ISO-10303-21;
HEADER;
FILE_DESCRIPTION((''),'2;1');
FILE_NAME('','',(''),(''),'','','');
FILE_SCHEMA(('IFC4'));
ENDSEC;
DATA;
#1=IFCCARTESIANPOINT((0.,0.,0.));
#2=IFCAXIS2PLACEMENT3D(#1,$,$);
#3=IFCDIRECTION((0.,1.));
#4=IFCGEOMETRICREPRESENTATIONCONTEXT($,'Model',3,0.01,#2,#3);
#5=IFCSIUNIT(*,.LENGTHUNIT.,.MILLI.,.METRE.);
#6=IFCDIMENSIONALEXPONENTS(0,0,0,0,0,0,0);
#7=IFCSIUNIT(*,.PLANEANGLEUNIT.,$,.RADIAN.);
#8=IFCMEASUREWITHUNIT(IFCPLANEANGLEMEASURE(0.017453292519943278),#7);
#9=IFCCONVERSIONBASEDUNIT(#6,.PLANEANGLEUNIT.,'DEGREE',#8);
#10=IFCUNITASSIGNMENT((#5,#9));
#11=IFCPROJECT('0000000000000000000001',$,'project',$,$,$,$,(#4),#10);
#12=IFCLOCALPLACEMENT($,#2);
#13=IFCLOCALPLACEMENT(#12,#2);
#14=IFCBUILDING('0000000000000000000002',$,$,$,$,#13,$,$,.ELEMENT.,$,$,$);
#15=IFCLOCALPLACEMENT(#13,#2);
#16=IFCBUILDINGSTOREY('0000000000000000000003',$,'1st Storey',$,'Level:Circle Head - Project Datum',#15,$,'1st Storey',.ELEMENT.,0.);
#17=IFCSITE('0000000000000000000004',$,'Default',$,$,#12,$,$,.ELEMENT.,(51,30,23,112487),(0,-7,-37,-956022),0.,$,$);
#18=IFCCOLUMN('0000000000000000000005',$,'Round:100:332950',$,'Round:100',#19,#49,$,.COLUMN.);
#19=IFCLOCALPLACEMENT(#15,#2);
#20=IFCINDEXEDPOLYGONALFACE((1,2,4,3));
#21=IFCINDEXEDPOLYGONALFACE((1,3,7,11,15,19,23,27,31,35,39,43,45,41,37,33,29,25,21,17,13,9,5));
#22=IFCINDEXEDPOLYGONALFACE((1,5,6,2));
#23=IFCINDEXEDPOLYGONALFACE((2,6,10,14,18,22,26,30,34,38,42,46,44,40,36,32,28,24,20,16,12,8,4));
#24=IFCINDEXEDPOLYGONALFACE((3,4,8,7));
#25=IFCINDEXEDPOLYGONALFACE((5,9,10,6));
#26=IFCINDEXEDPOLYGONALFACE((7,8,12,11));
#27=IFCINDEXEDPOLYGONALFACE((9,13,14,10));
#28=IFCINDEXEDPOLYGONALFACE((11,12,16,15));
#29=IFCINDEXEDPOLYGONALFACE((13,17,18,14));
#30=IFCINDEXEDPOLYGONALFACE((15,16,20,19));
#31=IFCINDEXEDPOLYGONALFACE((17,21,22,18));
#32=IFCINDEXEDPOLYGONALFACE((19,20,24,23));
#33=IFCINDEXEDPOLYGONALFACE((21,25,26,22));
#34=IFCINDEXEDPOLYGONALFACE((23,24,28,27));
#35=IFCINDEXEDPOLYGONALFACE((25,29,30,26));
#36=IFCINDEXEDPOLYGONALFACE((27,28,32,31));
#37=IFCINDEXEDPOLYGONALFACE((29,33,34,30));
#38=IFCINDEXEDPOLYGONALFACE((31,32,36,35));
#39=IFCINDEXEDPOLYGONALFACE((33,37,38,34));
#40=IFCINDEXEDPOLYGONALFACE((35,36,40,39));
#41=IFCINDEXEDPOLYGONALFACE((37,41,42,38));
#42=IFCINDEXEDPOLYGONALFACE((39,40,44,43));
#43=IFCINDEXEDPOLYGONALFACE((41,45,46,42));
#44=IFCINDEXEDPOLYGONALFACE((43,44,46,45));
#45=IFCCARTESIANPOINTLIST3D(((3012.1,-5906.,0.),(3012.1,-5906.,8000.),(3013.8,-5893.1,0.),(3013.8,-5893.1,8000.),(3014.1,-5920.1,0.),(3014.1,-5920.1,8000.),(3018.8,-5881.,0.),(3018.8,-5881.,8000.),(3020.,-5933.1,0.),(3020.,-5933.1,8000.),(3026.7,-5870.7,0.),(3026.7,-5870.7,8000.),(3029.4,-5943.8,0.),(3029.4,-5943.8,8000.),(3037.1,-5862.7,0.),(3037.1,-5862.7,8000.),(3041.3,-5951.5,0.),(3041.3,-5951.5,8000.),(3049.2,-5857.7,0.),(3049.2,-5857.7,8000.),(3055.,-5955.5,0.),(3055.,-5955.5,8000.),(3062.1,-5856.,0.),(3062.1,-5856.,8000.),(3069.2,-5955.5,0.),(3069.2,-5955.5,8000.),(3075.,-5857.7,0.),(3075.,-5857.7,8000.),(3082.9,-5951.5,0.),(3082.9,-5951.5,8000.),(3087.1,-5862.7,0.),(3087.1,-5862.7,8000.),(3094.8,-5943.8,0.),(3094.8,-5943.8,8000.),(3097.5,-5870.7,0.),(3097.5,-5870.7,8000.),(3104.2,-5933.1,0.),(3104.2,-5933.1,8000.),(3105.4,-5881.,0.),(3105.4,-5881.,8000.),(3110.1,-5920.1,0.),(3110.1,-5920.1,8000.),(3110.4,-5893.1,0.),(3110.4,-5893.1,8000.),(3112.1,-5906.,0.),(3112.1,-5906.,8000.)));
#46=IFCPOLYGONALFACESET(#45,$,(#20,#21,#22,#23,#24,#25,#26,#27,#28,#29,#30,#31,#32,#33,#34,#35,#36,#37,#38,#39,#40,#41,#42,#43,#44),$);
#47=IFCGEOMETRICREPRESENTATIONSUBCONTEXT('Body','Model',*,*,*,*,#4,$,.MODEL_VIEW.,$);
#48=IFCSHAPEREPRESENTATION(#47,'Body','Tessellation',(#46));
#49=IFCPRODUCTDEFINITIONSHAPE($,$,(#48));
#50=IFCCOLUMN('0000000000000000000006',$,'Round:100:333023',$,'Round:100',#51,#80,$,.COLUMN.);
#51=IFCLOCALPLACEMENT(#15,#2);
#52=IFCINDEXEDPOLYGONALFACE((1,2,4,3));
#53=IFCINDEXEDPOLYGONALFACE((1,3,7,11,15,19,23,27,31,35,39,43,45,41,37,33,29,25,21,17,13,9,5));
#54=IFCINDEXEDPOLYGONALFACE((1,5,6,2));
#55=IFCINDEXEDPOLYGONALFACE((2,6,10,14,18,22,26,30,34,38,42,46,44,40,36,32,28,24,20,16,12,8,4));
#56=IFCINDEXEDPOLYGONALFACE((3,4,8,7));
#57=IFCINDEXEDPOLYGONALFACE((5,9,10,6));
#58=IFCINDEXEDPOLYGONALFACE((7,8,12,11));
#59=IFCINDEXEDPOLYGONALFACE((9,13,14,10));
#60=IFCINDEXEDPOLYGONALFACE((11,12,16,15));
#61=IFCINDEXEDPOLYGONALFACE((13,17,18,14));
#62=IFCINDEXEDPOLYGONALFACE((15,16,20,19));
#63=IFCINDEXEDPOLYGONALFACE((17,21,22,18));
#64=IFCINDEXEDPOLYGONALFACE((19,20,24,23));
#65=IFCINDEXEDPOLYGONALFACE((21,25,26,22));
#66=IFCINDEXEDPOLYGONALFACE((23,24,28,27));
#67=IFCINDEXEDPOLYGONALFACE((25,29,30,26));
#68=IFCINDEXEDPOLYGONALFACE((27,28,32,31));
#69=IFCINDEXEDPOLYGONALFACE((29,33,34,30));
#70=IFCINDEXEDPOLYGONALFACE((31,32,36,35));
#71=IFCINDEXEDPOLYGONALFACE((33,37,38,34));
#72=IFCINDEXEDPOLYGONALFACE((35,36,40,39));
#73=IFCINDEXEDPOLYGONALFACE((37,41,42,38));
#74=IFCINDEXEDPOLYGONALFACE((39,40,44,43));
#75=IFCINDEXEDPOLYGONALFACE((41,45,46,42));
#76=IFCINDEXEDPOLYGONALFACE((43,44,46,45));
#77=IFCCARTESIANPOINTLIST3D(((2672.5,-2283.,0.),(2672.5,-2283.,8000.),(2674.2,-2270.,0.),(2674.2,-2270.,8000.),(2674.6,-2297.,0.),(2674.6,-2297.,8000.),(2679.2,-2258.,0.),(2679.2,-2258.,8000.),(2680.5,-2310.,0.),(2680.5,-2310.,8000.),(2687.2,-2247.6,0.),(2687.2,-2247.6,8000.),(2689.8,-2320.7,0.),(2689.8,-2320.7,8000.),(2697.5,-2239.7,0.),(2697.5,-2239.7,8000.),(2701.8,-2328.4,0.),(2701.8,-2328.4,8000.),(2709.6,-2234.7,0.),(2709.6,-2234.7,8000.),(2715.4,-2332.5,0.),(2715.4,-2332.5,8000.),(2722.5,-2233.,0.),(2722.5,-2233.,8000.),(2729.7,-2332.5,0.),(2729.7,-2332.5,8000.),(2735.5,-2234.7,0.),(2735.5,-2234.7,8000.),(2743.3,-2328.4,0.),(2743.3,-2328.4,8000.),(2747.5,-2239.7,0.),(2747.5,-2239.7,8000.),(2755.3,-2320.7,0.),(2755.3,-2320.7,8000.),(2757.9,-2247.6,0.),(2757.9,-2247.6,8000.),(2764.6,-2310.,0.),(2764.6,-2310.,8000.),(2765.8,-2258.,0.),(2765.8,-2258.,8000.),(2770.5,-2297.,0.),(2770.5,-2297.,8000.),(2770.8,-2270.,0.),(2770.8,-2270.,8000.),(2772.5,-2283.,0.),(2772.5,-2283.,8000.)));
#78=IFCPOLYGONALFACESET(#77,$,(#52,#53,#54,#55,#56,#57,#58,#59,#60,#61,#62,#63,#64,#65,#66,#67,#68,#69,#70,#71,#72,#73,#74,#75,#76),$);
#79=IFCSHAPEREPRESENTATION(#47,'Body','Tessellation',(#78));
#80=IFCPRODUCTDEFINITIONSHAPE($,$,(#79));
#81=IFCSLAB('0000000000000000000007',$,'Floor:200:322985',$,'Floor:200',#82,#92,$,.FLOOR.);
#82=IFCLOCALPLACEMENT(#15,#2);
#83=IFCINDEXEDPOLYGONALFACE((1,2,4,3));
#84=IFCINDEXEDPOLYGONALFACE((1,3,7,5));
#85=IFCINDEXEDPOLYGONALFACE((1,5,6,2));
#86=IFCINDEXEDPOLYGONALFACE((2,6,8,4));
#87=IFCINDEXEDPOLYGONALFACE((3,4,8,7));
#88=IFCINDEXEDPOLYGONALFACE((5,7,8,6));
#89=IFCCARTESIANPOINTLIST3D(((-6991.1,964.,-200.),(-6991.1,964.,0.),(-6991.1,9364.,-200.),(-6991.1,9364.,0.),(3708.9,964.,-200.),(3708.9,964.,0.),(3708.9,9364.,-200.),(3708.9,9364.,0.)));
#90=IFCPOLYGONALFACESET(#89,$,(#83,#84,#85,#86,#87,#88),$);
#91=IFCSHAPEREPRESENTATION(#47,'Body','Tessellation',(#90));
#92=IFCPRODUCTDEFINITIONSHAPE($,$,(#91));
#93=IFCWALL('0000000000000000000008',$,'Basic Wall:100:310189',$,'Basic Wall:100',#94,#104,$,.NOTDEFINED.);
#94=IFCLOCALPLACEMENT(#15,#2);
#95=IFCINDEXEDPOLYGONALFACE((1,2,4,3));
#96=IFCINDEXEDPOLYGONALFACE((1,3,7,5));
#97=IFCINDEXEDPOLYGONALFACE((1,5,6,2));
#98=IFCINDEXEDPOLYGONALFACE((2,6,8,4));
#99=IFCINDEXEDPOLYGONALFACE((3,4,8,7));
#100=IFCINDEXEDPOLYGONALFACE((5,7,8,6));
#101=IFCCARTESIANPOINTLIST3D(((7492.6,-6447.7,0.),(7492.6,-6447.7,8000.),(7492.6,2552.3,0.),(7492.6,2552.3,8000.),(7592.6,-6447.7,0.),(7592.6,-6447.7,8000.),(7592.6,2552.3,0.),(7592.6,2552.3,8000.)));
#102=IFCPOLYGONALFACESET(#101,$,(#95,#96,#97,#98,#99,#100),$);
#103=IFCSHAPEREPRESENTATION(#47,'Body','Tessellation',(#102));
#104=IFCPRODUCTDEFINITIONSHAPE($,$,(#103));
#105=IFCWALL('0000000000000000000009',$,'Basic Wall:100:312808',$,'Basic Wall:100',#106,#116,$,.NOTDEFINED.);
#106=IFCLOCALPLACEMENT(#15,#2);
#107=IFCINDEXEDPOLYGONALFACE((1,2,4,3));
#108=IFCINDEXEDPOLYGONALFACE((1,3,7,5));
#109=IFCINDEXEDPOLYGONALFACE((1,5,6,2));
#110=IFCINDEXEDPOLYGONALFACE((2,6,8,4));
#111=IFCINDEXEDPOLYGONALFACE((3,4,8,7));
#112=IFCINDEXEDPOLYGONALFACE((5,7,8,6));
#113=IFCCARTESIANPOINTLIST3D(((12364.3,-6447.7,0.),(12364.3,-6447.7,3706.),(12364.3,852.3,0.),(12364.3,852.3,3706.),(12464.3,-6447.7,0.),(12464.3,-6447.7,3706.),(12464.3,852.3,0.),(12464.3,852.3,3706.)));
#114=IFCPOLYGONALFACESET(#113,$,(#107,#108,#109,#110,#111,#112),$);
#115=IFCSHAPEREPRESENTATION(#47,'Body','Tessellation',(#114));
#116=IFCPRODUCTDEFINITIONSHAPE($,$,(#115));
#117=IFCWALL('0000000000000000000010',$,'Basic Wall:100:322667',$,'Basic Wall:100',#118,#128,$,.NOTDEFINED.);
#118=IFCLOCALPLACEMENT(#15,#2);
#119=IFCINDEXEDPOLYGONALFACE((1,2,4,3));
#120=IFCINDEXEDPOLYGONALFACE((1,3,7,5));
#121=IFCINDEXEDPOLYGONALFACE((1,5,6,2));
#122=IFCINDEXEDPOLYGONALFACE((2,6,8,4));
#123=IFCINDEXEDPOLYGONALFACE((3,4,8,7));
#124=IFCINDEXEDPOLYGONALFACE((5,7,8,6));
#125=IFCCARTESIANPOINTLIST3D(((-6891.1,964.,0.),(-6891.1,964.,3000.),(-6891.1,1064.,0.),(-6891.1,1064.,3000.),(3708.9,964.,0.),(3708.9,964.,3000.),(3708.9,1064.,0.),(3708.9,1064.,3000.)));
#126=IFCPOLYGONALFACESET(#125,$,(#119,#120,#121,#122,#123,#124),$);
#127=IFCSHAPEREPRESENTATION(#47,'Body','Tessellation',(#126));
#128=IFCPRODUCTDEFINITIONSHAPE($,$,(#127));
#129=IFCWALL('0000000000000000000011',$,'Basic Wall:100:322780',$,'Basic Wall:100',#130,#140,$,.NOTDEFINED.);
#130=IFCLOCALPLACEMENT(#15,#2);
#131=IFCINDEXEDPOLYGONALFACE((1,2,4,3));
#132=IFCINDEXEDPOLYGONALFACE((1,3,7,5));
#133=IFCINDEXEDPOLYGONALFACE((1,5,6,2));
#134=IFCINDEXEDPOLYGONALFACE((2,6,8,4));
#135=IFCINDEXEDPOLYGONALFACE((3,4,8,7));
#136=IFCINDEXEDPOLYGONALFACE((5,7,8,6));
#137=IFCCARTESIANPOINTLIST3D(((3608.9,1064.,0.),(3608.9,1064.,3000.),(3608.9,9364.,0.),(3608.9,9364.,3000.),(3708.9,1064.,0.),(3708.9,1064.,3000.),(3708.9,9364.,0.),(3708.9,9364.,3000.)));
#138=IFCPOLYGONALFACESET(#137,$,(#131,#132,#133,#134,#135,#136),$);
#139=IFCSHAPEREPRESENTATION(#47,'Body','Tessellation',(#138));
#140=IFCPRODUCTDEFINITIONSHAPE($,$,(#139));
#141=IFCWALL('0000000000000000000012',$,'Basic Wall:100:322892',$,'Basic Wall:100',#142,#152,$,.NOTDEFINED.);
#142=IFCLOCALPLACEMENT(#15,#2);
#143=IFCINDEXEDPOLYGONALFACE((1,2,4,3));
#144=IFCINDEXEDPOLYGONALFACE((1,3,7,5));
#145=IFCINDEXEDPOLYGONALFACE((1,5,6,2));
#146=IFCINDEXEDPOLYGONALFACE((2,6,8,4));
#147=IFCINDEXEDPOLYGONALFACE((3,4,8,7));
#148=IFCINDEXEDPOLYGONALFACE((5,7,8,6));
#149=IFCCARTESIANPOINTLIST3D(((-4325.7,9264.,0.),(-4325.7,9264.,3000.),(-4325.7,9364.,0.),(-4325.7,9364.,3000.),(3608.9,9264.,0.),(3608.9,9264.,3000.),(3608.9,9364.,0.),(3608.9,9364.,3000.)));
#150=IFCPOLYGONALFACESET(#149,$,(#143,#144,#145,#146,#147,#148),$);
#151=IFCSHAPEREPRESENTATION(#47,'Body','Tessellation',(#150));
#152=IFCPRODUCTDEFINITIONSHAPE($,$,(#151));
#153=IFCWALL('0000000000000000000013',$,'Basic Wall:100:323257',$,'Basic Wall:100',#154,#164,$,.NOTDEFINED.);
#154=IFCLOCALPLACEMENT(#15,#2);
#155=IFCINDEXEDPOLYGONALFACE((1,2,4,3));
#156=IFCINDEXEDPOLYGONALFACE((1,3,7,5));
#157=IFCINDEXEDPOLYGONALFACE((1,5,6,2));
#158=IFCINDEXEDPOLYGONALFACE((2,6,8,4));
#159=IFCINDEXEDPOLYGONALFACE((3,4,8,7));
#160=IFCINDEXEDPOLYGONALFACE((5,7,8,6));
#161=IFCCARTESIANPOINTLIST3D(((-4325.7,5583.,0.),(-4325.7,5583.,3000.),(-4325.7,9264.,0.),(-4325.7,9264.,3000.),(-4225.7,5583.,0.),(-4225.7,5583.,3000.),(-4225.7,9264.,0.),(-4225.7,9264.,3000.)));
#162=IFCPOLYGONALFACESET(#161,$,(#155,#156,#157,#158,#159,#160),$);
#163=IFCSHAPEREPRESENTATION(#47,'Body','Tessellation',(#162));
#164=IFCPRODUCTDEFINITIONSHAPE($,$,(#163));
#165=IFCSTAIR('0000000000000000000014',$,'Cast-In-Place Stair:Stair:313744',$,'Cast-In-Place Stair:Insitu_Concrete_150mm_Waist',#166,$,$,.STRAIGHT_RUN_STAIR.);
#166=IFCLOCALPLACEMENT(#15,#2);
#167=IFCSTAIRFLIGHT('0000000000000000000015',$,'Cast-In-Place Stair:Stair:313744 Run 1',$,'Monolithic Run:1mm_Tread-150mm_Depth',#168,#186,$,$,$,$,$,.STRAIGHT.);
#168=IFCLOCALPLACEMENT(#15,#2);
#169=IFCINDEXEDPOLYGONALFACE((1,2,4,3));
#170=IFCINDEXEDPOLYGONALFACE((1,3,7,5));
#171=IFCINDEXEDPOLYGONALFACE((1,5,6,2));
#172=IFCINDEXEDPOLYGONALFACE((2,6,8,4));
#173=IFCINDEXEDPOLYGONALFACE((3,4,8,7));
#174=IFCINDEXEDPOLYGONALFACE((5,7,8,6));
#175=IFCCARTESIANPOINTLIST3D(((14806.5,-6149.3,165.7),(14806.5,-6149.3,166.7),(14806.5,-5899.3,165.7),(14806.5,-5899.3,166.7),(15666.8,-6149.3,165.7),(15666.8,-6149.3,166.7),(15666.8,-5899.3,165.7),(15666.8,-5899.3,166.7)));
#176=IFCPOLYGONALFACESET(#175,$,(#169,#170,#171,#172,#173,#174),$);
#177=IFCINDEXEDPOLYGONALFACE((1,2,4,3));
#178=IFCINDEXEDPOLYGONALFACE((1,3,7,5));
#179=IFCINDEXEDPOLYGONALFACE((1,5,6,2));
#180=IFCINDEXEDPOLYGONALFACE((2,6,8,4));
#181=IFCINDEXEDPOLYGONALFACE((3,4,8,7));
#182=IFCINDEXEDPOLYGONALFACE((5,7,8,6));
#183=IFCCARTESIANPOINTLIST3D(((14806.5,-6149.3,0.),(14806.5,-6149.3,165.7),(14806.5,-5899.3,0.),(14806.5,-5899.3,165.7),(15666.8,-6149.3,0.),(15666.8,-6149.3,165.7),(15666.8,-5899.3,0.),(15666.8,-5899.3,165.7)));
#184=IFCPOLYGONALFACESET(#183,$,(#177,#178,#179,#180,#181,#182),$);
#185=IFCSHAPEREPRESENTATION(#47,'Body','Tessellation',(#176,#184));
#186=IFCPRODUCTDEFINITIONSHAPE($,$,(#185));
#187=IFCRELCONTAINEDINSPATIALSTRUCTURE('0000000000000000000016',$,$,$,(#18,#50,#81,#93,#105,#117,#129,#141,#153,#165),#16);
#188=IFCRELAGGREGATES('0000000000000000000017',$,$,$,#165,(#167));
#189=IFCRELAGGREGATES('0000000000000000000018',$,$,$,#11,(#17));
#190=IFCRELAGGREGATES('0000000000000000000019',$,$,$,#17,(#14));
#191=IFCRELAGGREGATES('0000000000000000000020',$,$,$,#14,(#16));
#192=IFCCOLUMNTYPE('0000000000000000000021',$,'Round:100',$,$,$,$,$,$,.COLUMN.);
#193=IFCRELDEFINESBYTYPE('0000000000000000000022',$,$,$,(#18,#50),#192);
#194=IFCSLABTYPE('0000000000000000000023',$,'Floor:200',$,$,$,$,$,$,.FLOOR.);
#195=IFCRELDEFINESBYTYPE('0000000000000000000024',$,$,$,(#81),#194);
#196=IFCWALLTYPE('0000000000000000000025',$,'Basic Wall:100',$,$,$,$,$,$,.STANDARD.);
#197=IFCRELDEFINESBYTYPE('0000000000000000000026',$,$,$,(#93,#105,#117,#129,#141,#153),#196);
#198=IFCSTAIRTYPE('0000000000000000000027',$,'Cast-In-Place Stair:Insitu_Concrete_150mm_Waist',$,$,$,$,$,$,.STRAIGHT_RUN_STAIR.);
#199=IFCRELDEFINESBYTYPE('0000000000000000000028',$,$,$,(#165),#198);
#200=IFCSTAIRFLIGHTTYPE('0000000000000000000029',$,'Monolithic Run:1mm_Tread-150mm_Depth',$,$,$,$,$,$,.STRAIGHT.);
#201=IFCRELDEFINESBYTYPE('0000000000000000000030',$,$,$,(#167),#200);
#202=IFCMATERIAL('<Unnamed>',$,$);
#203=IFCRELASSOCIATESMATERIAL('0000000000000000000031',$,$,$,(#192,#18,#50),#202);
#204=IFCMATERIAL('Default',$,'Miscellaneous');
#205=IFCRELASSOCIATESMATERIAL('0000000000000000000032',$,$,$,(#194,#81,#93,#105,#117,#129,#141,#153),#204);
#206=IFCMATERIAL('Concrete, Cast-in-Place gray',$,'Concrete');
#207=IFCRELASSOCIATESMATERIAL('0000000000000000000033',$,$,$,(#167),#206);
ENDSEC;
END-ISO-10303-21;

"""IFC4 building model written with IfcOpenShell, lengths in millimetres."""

from ifc_helpers import new_model, entity, si_unit, converted_unit, direction, frame, origin, place, context, subcontext, project, spatial, arc, indexed_curve, outline, extrude, source, transform, mapped, material, type_object, type_shapes, element, aggregate, save


model = new_model("IFC4")

# Units and contexts
model_context = context("Model", 3, precision=0.01, world=origin(), true_north=direction((0.0, 1.0)))
body_context = subcontext(model_context, "Body", "Model", "MODEL_VIEW")
ifc_project = project(units=[si_unit("LENGTHUNIT", "METRE", prefix="MILLI"), converted_unit("PLANEANGLEUNIT", "DEGREE", entity("IfcPlaneAngleMeasure", 0.017453292519943278), si_unit("PLANEANGLEUNIT", "RADIAN"), dimensions=[0, 0, 0, 0, 0, 0, 0])], contexts=[model_context])

# Site, building, storey
site_placement = place(None, origin())
site = spatial("IfcSite", under=ifc_project, at=site_placement, Name="Default", CompositionType="ELEMENT", RefLatitude=(51, 30, 23, 112487), RefLongitude=(0, -7, -37, -956022), RefElevation=0.0)
building_placement = place(site_placement, origin())
building = spatial("IfcBuilding", under=site, at=building_placement, CompositionType="ELEMENT")
storey_placement = place(building_placement, origin())
storey = spatial("IfcBuildingStorey", under=building, at=storey_placement, Name="1st Storey", ObjectType="Level:Circle Head - Project Datum", LongName="1st Storey", CompositionType="ELEMENT", Elevation=0.0)

# Columns
ifc_material_1 = material(Name="<Unnamed>")
column_type = type_object("IfcColumnType", Name="Round:100", PredefinedType="COLUMN", material=ifc_material_1)
shared_shape = source(origin(), body_context, "Body", "SweptSolid", [
    extrude(outline(indexed_curve([(50.0, -16.7), (35.4, 18.7), (0.0, 33.3), (-35.4, 18.7), (-50.0, -16.7), (0.0, -66.7)], segments=[arc(1, 2, 3), arc(3, 4, 5), arc(5, 6, 1)], self_intersect=False)), frame((0.0, 16.7, 0.0)), (0.0, 0.0, 1.0), 8000.0),
])
type_shapes(column_type, [shared_shape])
for number, where, name in (
    (1, (3062.1, -5906.0, 0.0), "Round:100:332950"),
    (2, (2722.5, -2283.0, 0.0), "Round:100:333023"),
):
    element("IfcColumn", number, at=place(storey_placement, frame(where)), inside=storey, type_object=column_type, material=ifc_material_1, Name=name, ObjectType="Round:100", PredefinedType="COLUMN", context=body_context, shape_type="MappedRepresentation", body=[
        mapped(shared_shape, transform((0.0, 0.0, 0.0), scale=1.0)),
    ])

# Slab
ifc_material_2 = material(Name="Default", Category="Miscellaneous")
slab_type = type_object("IfcSlabType", Name="Floor:200", PredefinedType="FLOOR", material=ifc_material_2)
slab_placement = place(storey_placement, origin())
element("IfcSlab", 3, at=slab_placement, inside=storey, type_object=slab_type, material=ifc_material_2, Name="Floor:200:322985", ObjectType="Floor:200", PredefinedType="FLOOR", context=body_context, shape_type="SweptSolid", body=[
    extrude(outline(indexed_curve([(-4200.0, -5350.0), (4200.0, -5350.0), (4200.0, 5350.0), (-4200.0, 5350.0), (-4200.0, -5350.0)], self_intersect=False)), frame((-1641.1, 5164.0, 0.0), z_axis=(0.0, 0.0, -1.0), x_axis=(0.0, 1.0, 0.0)), (0.0, 0.0, 1.0), 200.0),
])

# Walls
wall_type = type_object("IfcWallType", Name="Basic Wall:100", PredefinedType="STANDARD")
wall_1_placement = place(storey_placement, frame((7542.6, 2552.3, 0.0), z_axis=(0.0, 0.0, 1.0), x_axis=(0.0, -1.0, 0.0)))
element("IfcWall", 4, at=wall_1_placement, inside=storey, type_object=wall_type, material=ifc_material_2, Name="Basic Wall:100:310189", ObjectType="Basic Wall:100", PredefinedType="NOTDEFINED", context=body_context, shape_type="SweptSolid", body=[
    extrude(outline(indexed_curve([(9000.0, 50.0), (0.0, 50.0), (0.0, -50.0), (9000.0, -50.0), (9000.0, 50.0)], self_intersect=False)), origin(), (0.0, 0.0, 1.0), 8000.0),
])
wall_2_placement = place(storey_placement, frame((12414.3, -6447.7, 0.0), z_axis=(0.0, 0.0, 1.0), x_axis=(0.0, 1.0, 0.0)))
element("IfcWall", 5, at=wall_2_placement, inside=storey, type_object=wall_type, material=ifc_material_2, Name="Basic Wall:100:312808", ObjectType="Basic Wall:100", PredefinedType="NOTDEFINED", context=body_context, shape_type="SweptSolid", body=[
    extrude(outline(indexed_curve([(7300.0, 50.0), (0.0, 50.0), (0.0, -50.0), (7300.0, -50.0), (7300.0, 50.0)], self_intersect=False)), origin(), (0.0, 0.0, 1.0), 3706.0),
])
wall_3_placement = place(storey_placement, frame((-6891.1, 1014.0, 0.0)))
element("IfcWall", 6, at=wall_3_placement, inside=storey, type_object=wall_type, material=ifc_material_2, Name="Basic Wall:100:322667", ObjectType="Basic Wall:100", PredefinedType="NOTDEFINED", context=body_context, shape_type="SweptSolid", body=[
    extrude(outline(indexed_curve([(10600.0, 50.0), (0.0, 50.0), (0.0, -50.0), (10600.0, -50.0), (10600.0, 50.0)], self_intersect=False)), origin(), (0.0, 0.0, 1.0), 3000.0),
])
wall_4_placement = place(storey_placement, frame((3658.9, 1064.0, 0.0), z_axis=(0.0, 0.0, 1.0), x_axis=(0.0, 1.0, 0.0)))
element("IfcWall", 7, at=wall_4_placement, inside=storey, type_object=wall_type, material=ifc_material_2, Name="Basic Wall:100:322780", ObjectType="Basic Wall:100", PredefinedType="NOTDEFINED", context=body_context, shape_type="SweptSolid", body=[
    extrude(outline(indexed_curve([(8300.0, 50.0), (0.0, 50.0), (0.0, -50.0), (8300.0, -50.0), (8300.0, 50.0)], self_intersect=False)), origin(), (0.0, 0.0, 1.0), 3000.0),
])
wall_5_placement = place(storey_placement, frame((3608.9, 9314.0, 0.0), z_axis=(0.0, 0.0, 1.0), x_axis=(-1.0, 0.0, 0.0)))
element("IfcWall", 8, at=wall_5_placement, inside=storey, type_object=wall_type, material=ifc_material_2, Name="Basic Wall:100:322892", ObjectType="Basic Wall:100", PredefinedType="NOTDEFINED", context=body_context, shape_type="SweptSolid", body=[
    extrude(outline(indexed_curve([(7934.6, 50.0), (0.0, 50.0), (0.0, -50.0), (7934.6, -50.0), (7934.6, 50.0)], self_intersect=False)), origin(), (0.0, 0.0, 1.0), 3000.0),
])
wall_6_placement = place(storey_placement, frame((-4275.7, 5583.0, 0.0), z_axis=(0.0, 0.0, 1.0), x_axis=(0.0, 1.0, 0.0)))
element("IfcWall", 9, at=wall_6_placement, inside=storey, type_object=wall_type, material=ifc_material_2, Name="Basic Wall:100:323257", ObjectType="Basic Wall:100", PredefinedType="NOTDEFINED", context=body_context, shape_type="SweptSolid", body=[
    extrude(outline(indexed_curve([(3681.0, 50.0), (0.0, 50.0), (0.0, -50.0), (3681.0, -50.0), (3681.0, 50.0)], self_intersect=False)), origin(), (0.0, 0.0, 1.0), 3000.0),
])

# Stair, stair flight
stair_type_1 = type_object("IfcStairType", Name="Cast-In-Place Stair:Insitu_Concrete_150mm_Waist", PredefinedType="STRAIGHT_RUN_STAIR")
stair_1_placement = place(storey_placement, origin())
stair_1 = element("IfcStair", 10, at=stair_1_placement, inside=storey, type_object=stair_type_1, Name="Cast-In-Place Stair:Stair:313744", ObjectType="Cast-In-Place Stair:Insitu_Concrete_150mm_Waist", PredefinedType="STRAIGHT_RUN_STAIR")
ifc_material_3 = material(Name="Concrete, Cast-in-Place gray", Category="Concrete")
stair_flight_type = type_object("IfcStairFlightType", Name="Monolithic Run:1mm_Tread-150mm_Depth", PredefinedType="STRAIGHT")
stair_flight_placement = place(stair_1_placement, frame((14806.5, -6149.3, 0.0)))
stair_flight = element("IfcStairFlight", 11, at=stair_flight_placement, type_object=stair_flight_type, material=ifc_material_3, Name="Cast-In-Place Stair:Stair:313744 Run 1", ObjectType="Monolithic Run:1mm_Tread-150mm_Depth", PredefinedType="STRAIGHT", context=body_context, shape_type="SweptSolid", body=[
    extrude(outline(indexed_curve([(-125.0, -430.2), (125.0, -430.2), (125.0, 430.2), (-125.0, 430.2), (-125.0, -430.2)], self_intersect=False)), frame((430.2, 125.0, 165.7), z_axis=(0.0, 0.0, 1.0), x_axis=(0.0, -1.0, 0.0)), (0.0, 0.0, 1.0), 1.0),
    extrude(outline(indexed_curve([(-82.8, -125.0), (82.8, -125.0), (82.8, 125.0), (-82.8, 125.0), (-82.8, -125.0)], self_intersect=False)), frame((0.0, 125.0, 82.8), z_axis=(1.0, 0.0, 0.0), x_axis=(0.0, 0.0, -1.0)), (0.0, 0.0, 1.0), 860.3),
])
aggregate(stair_1, [stair_flight])

save(model, "model.ifc")
